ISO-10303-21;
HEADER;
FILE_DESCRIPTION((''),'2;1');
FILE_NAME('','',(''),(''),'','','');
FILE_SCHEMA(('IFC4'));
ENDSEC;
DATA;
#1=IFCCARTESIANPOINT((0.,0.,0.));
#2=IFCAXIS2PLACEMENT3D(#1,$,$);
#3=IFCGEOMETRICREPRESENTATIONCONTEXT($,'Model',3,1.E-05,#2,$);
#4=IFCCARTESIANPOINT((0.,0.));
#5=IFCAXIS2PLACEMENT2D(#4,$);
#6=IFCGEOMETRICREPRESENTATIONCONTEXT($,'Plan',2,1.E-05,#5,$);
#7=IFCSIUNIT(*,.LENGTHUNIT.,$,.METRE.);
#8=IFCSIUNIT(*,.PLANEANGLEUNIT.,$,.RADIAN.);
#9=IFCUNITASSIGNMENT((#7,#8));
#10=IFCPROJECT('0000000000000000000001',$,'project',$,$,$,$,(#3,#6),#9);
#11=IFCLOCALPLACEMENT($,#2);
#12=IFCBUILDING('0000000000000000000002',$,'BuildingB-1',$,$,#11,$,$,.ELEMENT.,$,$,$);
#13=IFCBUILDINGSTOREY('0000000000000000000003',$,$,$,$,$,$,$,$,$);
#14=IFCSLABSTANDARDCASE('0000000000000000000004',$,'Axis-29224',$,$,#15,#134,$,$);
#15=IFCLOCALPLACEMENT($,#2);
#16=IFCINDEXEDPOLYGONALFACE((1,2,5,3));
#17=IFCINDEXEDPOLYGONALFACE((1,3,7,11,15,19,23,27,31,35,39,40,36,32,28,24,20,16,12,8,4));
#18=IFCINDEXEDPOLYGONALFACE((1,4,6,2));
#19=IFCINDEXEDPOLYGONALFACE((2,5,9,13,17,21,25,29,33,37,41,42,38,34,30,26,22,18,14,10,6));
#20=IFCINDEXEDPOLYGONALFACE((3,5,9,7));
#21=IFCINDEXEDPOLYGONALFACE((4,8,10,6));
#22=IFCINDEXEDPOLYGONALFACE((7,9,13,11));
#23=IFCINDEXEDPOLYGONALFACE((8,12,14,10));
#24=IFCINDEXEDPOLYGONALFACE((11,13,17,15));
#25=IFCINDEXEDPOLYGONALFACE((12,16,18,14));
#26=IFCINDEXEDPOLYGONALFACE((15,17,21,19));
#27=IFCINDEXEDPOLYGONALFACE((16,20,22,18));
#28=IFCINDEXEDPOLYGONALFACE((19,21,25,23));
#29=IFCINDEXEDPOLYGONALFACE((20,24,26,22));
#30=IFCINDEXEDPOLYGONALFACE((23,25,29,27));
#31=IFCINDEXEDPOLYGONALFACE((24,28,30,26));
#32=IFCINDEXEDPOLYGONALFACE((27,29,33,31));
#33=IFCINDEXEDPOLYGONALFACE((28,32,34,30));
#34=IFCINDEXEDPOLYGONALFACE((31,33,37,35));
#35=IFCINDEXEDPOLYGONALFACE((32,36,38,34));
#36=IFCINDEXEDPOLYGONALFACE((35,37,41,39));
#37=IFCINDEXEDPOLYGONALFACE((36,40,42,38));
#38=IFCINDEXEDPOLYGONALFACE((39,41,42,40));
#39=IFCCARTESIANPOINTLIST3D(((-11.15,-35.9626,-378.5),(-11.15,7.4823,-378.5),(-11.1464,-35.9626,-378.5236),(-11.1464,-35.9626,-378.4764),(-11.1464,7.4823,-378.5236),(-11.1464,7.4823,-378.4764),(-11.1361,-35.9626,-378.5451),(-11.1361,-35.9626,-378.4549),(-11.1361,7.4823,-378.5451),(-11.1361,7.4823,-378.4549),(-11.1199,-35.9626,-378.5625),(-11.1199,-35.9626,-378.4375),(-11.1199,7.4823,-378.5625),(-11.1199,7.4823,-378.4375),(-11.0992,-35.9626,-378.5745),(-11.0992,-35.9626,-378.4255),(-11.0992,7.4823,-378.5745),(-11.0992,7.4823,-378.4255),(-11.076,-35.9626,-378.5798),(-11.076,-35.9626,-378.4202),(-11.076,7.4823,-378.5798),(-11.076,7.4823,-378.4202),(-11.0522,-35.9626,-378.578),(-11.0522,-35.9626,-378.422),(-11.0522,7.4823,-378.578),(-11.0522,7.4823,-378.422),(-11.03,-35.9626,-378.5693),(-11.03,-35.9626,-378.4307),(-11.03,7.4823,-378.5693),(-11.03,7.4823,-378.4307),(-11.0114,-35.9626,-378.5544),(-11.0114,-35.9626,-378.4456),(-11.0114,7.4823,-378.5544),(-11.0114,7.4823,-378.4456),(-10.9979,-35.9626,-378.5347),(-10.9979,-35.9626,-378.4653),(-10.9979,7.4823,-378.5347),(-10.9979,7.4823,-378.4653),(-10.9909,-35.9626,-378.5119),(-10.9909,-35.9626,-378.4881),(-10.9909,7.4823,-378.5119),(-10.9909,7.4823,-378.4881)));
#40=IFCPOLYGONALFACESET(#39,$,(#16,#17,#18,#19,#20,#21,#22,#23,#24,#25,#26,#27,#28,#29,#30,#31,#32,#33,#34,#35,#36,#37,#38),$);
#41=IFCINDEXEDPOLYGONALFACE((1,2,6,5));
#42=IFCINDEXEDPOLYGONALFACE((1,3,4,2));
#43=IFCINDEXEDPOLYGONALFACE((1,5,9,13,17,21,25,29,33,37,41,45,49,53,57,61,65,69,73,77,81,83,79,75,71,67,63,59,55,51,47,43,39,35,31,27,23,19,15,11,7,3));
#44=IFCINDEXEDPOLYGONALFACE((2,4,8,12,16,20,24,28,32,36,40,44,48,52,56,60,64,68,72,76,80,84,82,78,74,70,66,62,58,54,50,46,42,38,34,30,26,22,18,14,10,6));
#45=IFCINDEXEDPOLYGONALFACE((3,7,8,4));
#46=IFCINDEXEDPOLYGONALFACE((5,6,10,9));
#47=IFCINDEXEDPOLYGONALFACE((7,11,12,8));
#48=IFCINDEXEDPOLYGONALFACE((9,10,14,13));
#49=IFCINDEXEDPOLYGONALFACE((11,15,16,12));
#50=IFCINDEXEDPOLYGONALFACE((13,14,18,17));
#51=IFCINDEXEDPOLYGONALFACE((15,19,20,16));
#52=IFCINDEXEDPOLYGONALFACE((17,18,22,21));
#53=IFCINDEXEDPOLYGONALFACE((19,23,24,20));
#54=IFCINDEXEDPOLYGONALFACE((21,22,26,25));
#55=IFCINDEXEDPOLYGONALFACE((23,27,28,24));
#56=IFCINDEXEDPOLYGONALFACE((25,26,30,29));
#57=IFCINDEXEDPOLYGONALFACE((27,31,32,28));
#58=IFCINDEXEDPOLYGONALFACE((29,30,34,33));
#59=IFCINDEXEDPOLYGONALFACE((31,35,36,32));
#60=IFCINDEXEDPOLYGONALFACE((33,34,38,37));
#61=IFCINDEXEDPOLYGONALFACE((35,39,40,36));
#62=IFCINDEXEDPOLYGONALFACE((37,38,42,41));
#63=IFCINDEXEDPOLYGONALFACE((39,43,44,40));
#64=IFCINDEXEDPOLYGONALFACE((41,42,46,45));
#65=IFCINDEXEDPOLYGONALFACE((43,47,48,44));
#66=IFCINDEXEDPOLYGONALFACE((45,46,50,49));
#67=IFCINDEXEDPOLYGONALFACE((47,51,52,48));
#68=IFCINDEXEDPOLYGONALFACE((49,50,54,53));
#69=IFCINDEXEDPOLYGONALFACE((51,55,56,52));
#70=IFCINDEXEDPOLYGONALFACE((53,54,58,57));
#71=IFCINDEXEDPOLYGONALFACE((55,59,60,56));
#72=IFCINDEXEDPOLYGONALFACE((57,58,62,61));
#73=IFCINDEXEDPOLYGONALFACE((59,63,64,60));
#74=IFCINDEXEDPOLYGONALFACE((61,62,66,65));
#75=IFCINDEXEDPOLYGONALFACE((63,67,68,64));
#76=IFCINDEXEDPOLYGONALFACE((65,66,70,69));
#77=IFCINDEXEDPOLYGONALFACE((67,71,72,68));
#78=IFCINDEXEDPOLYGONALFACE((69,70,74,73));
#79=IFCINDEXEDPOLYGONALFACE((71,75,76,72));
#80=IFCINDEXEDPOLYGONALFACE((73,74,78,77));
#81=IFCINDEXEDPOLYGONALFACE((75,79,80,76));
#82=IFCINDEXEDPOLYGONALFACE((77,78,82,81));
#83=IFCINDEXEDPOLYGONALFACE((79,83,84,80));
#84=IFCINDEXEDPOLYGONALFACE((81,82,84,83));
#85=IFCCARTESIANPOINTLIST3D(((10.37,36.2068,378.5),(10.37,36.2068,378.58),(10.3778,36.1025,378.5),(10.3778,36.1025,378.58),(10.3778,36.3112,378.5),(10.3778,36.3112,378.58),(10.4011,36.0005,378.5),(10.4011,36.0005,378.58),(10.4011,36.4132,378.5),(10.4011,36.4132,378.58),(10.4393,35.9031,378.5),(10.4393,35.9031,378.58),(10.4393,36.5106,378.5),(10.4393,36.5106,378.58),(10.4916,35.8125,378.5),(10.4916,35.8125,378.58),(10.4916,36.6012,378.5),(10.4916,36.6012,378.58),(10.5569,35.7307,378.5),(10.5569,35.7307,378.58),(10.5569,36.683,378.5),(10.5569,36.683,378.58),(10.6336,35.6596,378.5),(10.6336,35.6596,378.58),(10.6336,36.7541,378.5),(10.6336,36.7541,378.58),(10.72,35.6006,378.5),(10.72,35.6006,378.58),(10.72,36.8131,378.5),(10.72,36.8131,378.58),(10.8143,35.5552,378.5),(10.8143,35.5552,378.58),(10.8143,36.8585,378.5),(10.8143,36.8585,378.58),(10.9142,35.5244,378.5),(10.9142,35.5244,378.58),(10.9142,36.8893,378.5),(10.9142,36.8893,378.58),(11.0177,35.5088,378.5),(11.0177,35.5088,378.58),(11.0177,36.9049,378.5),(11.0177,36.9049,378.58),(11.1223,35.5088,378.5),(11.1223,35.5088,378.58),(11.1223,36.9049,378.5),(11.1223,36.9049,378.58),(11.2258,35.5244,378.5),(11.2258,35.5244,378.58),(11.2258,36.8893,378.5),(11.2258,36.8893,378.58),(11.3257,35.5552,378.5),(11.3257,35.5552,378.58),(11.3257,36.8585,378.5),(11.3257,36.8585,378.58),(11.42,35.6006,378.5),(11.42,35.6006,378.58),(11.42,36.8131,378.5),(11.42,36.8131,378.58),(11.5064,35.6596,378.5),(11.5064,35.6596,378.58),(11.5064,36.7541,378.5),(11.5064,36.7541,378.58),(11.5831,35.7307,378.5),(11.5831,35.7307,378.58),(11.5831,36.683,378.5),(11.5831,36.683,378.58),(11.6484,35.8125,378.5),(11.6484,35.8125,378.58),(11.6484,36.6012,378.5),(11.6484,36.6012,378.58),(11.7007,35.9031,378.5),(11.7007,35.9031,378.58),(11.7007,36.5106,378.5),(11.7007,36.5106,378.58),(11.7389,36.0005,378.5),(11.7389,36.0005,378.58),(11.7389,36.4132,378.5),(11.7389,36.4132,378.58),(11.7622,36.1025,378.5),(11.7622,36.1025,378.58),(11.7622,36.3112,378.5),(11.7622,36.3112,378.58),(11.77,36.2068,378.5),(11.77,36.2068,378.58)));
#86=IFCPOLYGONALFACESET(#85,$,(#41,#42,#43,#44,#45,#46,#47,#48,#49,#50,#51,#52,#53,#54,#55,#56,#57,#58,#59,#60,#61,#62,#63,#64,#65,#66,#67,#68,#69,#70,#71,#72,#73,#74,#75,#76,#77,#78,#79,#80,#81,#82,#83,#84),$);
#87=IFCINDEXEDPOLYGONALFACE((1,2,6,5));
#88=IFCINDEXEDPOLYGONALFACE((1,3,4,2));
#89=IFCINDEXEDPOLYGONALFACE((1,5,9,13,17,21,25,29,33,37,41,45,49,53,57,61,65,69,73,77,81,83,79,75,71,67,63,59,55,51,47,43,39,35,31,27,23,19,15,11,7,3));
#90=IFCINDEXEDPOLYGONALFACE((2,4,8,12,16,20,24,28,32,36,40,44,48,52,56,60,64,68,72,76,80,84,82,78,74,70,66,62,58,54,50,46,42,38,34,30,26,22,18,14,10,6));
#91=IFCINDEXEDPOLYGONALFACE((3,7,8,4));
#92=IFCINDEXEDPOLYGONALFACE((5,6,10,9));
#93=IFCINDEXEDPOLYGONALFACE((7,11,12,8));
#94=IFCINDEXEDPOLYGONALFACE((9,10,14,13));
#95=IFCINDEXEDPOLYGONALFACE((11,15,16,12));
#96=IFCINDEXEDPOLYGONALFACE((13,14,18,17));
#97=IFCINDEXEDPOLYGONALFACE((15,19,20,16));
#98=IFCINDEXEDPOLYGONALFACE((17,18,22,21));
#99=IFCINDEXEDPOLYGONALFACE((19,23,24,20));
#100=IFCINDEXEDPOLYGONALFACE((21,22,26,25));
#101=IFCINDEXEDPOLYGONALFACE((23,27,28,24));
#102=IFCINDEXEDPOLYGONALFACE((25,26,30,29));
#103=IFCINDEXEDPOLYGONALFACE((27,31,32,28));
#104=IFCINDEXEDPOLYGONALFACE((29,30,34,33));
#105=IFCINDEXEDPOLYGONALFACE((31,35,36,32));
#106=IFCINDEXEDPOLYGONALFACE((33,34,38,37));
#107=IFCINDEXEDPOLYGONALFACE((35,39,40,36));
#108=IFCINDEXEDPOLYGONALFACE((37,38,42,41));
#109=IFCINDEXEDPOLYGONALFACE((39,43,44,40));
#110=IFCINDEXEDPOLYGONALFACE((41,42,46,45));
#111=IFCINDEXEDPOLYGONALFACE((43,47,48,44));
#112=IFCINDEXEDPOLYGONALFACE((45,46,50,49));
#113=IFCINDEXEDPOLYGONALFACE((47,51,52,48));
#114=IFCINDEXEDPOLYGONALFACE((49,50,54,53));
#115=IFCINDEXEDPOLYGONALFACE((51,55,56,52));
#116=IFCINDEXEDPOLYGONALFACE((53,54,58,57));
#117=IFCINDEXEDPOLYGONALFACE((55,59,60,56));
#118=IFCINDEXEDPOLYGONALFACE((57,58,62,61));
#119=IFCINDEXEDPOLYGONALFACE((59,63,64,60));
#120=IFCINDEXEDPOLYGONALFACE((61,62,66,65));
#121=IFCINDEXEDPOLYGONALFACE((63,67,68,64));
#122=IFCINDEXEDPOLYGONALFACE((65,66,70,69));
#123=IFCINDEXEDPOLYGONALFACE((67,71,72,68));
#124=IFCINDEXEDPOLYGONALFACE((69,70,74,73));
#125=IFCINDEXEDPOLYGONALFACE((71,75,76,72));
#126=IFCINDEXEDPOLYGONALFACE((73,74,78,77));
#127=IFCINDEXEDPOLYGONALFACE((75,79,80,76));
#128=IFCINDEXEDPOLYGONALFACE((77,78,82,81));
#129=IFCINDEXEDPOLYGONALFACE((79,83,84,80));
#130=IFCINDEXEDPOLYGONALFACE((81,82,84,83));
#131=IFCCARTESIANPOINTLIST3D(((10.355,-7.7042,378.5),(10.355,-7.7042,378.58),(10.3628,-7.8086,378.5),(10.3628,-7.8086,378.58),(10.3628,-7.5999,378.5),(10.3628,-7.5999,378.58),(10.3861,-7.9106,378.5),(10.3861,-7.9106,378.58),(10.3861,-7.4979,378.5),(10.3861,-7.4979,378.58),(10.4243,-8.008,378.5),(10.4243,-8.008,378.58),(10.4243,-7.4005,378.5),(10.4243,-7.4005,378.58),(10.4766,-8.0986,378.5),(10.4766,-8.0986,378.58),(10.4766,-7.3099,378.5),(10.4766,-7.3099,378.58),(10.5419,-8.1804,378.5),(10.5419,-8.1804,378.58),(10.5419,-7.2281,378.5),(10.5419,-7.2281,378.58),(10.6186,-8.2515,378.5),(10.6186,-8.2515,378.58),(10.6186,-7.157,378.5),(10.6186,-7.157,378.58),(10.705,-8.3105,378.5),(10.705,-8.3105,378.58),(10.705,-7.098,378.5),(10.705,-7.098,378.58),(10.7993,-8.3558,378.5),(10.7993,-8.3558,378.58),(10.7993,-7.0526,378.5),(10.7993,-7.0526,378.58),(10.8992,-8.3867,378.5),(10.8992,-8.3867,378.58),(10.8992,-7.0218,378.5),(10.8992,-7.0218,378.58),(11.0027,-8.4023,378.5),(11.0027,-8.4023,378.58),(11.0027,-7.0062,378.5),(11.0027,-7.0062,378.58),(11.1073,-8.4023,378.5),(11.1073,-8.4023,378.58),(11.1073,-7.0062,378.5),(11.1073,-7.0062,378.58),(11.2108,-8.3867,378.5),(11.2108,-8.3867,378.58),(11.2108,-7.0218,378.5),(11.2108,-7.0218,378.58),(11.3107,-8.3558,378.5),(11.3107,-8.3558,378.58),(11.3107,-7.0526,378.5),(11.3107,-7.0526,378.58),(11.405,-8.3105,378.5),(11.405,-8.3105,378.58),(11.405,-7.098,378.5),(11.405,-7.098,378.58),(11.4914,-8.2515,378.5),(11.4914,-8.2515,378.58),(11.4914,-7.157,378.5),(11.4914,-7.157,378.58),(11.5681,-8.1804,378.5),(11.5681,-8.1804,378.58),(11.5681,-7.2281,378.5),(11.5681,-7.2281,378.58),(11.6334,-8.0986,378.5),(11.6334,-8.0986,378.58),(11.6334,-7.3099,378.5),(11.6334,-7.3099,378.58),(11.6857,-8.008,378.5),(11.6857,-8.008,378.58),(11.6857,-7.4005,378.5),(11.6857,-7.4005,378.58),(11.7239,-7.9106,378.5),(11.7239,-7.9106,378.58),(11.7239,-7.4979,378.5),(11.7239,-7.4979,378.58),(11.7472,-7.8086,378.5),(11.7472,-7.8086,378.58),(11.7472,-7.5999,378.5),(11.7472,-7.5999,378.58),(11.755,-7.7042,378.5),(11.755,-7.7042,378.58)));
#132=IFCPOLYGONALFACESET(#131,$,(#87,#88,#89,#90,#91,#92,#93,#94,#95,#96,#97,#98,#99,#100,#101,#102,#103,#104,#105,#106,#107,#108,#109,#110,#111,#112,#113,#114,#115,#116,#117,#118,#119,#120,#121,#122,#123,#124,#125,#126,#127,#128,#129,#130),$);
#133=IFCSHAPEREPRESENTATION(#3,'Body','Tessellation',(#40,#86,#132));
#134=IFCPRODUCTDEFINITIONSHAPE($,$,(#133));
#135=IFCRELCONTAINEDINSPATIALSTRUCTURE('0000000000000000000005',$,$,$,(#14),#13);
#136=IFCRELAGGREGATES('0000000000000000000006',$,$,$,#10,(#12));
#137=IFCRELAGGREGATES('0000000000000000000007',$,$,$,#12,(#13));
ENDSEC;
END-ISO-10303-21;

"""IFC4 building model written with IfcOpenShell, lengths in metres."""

from ifc_helpers import new_model, entity, si_unit, frame, origin, origin_2d, place, context, project, spatial, circle, extrude, element, save


model = new_model("IFC4")

# Units and contexts
model_context = context("Model", 3, precision=1e-05, world=origin())
plan_context = context("Plan", 2, precision=1e-05, world=origin_2d())
ifc_project = project(units=[si_unit("LENGTHUNIT", "METRE"), si_unit("PLANEANGLEUNIT", "RADIAN")], contexts=[model_context, plan_context])

# Building, storey
building_placement = place(None, origin())
building = spatial("IfcBuilding", under=ifc_project, at=building_placement, Name="BuildingB-1", CompositionType="ELEMENT")
storey = spatial("IfcBuildingStorey", under=building)

# Slab
element("IfcSlabStandardCase", 1, inside=storey, Name="Axis-29224", context=model_context, shape_type="AdvancedSweptSolid", body=[
    entity("IfcSurfaceCurveSweptAreaSolid", entity("IfcCircleProfileDef", "AREA", None, None, 0.08), None, entity("IfcPolyline", [entity("IfcCartesianPoint", [11.07, 35.9626, 378.5]), entity("IfcCartesianPoint", [11.07, -7.4823, 378.5])]), None, None, entity("IfcPlane", entity("IfcAxis2Placement3D", entity("IfcCartesianPoint", [11.07, 35.9626, 378.5]), entity("IfcDirection", [0.0, 0.0, 1.0]), entity("IfcDirection", [1.0, 0.0, 0.0])))),
    extrude(circle(Radius=0.7), frame((11.07, 36.2068, 378.5)), (0.0, 0.0, 1.0), 0.08),
    extrude(circle(Radius=0.7), frame((11.055, -7.7042, 378.5)), (0.0, 0.0, 1.0), 0.08),
])

save(model, "model.ifc")
